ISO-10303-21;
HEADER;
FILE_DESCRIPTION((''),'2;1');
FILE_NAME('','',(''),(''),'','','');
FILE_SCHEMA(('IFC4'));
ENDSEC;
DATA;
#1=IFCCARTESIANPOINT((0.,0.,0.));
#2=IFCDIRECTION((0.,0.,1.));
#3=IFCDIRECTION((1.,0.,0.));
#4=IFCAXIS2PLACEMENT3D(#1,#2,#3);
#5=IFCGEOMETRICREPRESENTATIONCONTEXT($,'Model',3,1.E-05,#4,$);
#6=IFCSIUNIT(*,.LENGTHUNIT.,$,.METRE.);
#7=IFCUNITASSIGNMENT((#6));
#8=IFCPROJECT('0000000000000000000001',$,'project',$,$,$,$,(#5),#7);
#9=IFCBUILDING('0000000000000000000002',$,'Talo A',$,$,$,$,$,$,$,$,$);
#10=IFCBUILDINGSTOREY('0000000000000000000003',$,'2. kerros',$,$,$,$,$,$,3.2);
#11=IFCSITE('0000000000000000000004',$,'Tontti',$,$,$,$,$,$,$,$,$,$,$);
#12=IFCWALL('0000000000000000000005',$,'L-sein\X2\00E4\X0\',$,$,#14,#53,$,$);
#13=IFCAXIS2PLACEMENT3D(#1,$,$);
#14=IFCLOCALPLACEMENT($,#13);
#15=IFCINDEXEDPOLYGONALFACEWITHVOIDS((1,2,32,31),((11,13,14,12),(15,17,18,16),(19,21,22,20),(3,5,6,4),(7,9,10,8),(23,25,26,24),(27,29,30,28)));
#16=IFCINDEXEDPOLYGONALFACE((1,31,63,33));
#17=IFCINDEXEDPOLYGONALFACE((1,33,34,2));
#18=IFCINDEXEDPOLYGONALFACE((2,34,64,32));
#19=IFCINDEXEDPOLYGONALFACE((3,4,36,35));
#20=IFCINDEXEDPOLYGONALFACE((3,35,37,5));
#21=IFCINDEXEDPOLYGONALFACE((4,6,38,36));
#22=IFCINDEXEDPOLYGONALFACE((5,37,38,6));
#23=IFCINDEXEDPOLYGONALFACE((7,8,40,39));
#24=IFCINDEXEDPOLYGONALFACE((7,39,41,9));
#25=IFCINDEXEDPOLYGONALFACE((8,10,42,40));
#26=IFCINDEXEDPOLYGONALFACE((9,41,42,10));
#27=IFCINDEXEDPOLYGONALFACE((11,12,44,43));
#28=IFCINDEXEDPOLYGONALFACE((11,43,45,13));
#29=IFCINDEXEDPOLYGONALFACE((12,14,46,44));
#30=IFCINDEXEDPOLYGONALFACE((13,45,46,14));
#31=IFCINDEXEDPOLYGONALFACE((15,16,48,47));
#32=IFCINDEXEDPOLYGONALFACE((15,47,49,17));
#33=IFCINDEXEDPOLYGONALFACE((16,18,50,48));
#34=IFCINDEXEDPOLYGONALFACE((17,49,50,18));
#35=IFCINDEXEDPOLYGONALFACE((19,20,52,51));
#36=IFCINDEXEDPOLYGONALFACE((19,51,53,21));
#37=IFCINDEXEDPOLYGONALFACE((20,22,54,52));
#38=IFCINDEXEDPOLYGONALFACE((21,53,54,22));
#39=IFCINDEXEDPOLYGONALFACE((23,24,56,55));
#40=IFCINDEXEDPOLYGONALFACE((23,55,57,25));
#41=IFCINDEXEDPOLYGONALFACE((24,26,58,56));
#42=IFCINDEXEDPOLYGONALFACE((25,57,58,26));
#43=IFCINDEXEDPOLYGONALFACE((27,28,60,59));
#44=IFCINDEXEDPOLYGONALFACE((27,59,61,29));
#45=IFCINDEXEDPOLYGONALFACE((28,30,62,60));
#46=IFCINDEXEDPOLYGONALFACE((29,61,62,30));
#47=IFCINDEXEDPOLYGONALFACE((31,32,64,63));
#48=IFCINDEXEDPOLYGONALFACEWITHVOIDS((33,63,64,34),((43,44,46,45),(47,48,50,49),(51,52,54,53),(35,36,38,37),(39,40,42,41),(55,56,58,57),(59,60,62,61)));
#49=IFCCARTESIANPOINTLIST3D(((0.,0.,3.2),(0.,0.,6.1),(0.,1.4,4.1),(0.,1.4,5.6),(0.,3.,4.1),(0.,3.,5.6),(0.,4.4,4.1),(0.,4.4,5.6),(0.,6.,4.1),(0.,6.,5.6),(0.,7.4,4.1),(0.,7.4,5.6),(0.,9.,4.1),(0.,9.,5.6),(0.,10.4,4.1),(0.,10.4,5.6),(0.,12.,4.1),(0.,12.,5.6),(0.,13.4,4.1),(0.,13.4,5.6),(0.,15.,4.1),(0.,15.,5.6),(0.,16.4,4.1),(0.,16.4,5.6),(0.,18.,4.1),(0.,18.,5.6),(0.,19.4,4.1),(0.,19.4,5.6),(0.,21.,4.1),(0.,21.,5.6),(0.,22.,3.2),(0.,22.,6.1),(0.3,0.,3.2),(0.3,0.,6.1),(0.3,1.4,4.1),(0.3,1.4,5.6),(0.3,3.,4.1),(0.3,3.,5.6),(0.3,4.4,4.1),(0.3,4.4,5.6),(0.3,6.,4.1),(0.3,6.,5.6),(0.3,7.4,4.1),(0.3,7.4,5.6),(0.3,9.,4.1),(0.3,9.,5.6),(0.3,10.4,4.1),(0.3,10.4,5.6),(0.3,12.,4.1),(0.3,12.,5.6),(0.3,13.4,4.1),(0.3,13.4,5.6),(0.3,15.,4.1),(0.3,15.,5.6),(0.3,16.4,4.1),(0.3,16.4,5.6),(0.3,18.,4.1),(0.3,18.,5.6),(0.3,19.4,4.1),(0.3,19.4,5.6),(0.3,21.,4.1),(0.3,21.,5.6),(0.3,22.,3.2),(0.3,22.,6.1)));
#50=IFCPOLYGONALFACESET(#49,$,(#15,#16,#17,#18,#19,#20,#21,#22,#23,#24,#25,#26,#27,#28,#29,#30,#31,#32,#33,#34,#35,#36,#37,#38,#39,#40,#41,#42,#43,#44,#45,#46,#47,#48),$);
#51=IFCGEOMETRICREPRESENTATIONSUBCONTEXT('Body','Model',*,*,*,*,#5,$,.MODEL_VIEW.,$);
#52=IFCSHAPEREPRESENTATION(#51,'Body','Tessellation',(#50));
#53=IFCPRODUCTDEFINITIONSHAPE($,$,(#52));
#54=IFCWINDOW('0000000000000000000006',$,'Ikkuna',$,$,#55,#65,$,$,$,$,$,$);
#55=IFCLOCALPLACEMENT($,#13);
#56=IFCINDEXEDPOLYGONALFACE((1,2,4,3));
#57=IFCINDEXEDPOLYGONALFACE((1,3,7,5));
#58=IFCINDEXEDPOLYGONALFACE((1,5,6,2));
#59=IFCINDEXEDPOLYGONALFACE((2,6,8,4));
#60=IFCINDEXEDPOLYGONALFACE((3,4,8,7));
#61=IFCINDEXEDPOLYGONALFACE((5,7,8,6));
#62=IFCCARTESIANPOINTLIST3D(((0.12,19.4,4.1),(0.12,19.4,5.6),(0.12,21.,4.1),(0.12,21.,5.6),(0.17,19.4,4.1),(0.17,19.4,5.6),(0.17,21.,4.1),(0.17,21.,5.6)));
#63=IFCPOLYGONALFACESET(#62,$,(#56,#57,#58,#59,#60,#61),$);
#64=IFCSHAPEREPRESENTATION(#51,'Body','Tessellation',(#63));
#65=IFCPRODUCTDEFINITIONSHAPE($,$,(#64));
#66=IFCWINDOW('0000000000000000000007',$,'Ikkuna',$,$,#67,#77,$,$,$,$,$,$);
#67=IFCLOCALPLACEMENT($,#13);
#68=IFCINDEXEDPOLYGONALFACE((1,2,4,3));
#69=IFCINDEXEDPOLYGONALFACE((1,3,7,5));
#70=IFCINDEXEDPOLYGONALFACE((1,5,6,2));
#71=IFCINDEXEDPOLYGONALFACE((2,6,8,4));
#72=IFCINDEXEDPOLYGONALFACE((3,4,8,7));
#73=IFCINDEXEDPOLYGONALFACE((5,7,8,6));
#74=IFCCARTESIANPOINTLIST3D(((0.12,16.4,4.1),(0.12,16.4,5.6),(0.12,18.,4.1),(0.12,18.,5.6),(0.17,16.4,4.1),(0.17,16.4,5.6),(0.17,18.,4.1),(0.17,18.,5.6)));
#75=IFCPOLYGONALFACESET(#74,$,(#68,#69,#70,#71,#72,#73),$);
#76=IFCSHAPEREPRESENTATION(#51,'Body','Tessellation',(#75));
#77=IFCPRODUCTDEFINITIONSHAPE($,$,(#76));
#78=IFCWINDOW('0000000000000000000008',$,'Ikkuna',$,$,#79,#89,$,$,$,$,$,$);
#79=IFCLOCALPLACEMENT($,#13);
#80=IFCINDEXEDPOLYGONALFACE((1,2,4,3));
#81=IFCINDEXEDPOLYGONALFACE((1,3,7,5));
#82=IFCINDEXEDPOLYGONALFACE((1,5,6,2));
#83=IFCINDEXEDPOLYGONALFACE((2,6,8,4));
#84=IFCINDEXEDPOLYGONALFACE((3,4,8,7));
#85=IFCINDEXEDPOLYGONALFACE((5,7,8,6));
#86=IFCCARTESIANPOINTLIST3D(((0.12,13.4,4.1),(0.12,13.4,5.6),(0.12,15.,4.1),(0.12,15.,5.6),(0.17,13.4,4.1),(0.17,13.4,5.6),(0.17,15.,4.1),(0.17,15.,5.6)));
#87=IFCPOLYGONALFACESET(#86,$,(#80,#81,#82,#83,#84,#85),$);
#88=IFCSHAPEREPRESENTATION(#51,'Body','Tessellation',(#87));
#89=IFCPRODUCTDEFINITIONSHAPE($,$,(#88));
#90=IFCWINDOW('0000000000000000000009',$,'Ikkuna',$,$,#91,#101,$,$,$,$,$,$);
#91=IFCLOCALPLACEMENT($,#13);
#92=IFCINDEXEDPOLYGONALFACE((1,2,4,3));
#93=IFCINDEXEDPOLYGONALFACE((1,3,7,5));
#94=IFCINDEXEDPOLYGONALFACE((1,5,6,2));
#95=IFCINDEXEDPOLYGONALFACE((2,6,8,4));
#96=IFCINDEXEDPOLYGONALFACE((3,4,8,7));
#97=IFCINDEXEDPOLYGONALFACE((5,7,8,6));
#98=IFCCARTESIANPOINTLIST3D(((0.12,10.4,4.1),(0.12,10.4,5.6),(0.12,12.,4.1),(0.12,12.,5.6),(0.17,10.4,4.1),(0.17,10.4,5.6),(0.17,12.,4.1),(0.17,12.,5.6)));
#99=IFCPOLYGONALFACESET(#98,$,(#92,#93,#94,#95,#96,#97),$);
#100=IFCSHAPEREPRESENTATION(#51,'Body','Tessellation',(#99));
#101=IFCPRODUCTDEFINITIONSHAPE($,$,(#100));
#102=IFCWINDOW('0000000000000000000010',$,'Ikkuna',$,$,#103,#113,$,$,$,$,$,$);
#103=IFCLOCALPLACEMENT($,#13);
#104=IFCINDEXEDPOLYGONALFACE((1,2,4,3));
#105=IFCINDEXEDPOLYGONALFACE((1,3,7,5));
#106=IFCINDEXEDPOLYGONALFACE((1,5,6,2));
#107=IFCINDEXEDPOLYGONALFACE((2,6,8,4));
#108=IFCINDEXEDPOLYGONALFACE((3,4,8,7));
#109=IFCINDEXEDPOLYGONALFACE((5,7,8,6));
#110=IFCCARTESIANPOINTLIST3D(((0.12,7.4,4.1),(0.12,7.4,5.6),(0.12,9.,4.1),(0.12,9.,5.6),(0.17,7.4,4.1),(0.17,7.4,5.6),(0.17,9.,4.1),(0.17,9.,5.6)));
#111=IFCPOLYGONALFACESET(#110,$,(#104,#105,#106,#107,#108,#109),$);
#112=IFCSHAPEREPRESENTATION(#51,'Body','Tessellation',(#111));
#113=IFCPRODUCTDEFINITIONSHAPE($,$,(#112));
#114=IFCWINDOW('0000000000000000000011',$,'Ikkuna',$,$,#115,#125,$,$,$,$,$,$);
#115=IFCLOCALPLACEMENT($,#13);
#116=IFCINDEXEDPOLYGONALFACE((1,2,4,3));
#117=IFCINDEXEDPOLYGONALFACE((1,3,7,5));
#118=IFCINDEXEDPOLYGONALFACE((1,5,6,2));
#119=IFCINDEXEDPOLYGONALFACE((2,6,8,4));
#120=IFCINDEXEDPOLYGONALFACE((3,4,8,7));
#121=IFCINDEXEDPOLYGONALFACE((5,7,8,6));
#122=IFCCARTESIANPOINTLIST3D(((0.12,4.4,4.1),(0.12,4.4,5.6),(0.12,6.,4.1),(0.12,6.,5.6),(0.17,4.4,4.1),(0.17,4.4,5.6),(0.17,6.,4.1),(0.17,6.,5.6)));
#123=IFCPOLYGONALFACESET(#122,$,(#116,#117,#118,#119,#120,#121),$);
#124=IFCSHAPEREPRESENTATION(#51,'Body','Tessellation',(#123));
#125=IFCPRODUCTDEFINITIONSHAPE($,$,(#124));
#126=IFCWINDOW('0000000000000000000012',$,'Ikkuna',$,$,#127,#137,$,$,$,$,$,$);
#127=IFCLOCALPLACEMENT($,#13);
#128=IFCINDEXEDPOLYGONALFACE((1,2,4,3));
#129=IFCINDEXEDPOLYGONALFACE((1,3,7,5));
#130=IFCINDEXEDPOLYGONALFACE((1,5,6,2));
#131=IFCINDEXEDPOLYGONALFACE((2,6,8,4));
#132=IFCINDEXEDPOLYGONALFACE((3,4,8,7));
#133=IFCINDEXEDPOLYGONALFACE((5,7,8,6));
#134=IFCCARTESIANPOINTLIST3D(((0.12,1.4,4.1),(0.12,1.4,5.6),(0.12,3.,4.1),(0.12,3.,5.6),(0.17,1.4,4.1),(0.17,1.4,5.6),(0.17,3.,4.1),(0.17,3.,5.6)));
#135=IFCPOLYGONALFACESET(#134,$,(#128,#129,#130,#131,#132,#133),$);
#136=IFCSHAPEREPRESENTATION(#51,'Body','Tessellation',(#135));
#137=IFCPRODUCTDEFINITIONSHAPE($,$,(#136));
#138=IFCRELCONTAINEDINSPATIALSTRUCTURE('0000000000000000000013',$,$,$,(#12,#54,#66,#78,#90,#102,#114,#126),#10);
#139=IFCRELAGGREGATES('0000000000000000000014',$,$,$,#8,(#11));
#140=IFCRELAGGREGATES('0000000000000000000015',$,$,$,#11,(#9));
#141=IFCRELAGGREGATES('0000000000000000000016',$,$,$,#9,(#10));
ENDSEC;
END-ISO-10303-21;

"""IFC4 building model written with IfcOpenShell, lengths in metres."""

from ifc_helpers import new_model, si_unit, frame, origin_with_axes, place, context, subcontext, project, spatial, indexed_curve, outline, extrude, element, save


model = new_model("IFC4")

# Units and contexts
model_context = context("Model", 3, precision=1e-05, world=origin_with_axes())
body_context = subcontext(model_context, "Body", "Model", "MODEL_VIEW")
ifc_project = project(units=[si_unit("LENGTHUNIT", "METRE")], contexts=[model_context])

# Site, building, storey
site = spatial("IfcSite", under=ifc_project, Name="Tontti")
building = spatial("IfcBuilding", under=site, Name="Talo A")
storey = spatial("IfcBuildingStorey", under=building, Name="2. kerros", Elevation=3.2)

# Wall, openings
wall_1_placement = place(None, frame((0.0, 22.0, 3.2), z_axis=(0.0, 0.0, 1.0), x_axis=(0.0, -1.0, 0.0)))
wall_1 = element("IfcWall", 1, at=wall_1_placement, inside=storey, Name="L-seinä", context=body_context, shape_type="SweptSolid", body=[
    extrude(outline(indexed_curve([(0.0, 0.0), (0.0, 0.3), (22.0, 0.3), (22.0, 0.0), (0.0, 0.0)], self_intersect=False)), origin_with_axes(), (0.0, 0.0, 1.0), 2.9),
])
opening_1_placement = place(wall_1_placement, frame((1.0, -0.1, 0.9), z_axis=(0.0, 0.0, 1.0), x_axis=(1.0, 0.0, 0.0)))
element("IfcOpeningElement", 2, at=opening_1_placement, cuts=wall_1, context=body_context, shape_type="SweptSolid", body=[
    extrude(outline(indexed_curve([(0.0, 0.0), (0.0, 0.5), (1.6, 0.5), (1.6, 0.0), (0.0, 0.0)], self_intersect=False)), origin_with_axes(), (0.0, 0.0, 1.0), 1.5),
])
opening_2_placement = place(wall_1_placement, frame((4.0, -0.1, 0.9), z_axis=(0.0, 0.0, 1.0), x_axis=(1.0, 0.0, 0.0)))
element("IfcOpeningElement", 3, at=opening_2_placement, cuts=wall_1, context=body_context, shape_type="SweptSolid", body=[
    extrude(outline(indexed_curve([(0.0, 0.0), (0.0, 0.5), (1.6, 0.5), (1.6, 0.0), (0.0, 0.0)], self_intersect=False)), origin_with_axes(), (0.0, 0.0, 1.0), 1.5),
])
opening_3_placement = place(wall_1_placement, frame((7.0, -0.1, 0.9), z_axis=(0.0, 0.0, 1.0), x_axis=(1.0, 0.0, 0.0)))
element("IfcOpeningElement", 4, at=opening_3_placement, cuts=wall_1, context=body_context, shape_type="SweptSolid", body=[
    extrude(outline(indexed_curve([(0.0, 0.0), (0.0, 0.5), (1.6, 0.5), (1.6, 0.0), (0.0, 0.0)], self_intersect=False)), origin_with_axes(), (0.0, 0.0, 1.0), 1.5),
])
opening_4_placement = place(wall_1_placement, frame((10.0, -0.1, 0.9), z_axis=(0.0, 0.0, 1.0), x_axis=(1.0, 0.0, 0.0)))
element("IfcOpeningElement", 5, at=opening_4_placement, cuts=wall_1, context=body_context, shape_type="SweptSolid", body=[
    extrude(outline(indexed_curve([(0.0, 0.0), (0.0, 0.5), (1.6, 0.5), (1.6, 0.0), (0.0, 0.0)], self_intersect=False)), origin_with_axes(), (0.0, 0.0, 1.0), 1.5),
])
opening_5_placement = place(wall_1_placement, frame((13.0, -0.1, 0.9), z_axis=(0.0, 0.0, 1.0), x_axis=(1.0, 0.0, 0.0)))
element("IfcOpeningElement", 6, at=opening_5_placement, cuts=wall_1, context=body_context, shape_type="SweptSolid", body=[
    extrude(outline(indexed_curve([(0.0, 0.0), (0.0, 0.5), (1.6, 0.5), (1.6, 0.0), (0.0, 0.0)], self_intersect=False)), origin_with_axes(), (0.0, 0.0, 1.0), 1.5),
])
opening_6_placement = place(wall_1_placement, frame((16.0, -0.1, 0.9), z_axis=(0.0, 0.0, 1.0), x_axis=(1.0, 0.0, 0.0)))
element("IfcOpeningElement", 7, at=opening_6_placement, cuts=wall_1, context=body_context, shape_type="SweptSolid", body=[
    extrude(outline(indexed_curve([(0.0, 0.0), (0.0, 0.5), (1.6, 0.5), (1.6, 0.0), (0.0, 0.0)], self_intersect=False)), origin_with_axes(), (0.0, 0.0, 1.0), 1.5),
])
opening_7_placement = place(wall_1_placement, frame((19.0, -0.1, 0.9), z_axis=(0.0, 0.0, 1.0), x_axis=(1.0, 0.0, 0.0)))
element("IfcOpeningElement", 8, at=opening_7_placement, cuts=wall_1, context=body_context, shape_type="SweptSolid", body=[
    extrude(outline(indexed_curve([(0.0, 0.0), (0.0, 0.5), (1.6, 0.5), (1.6, 0.0), (0.0, 0.0)], self_intersect=False)), origin_with_axes(), (0.0, 0.0, 1.0), 1.5),
])

# Windows
for number, where, z_axis, x_axis, name in (
    (9, (0.12, 21.0, 4.1), (0.0, 0.0, 1.0), (0.0, -1.0, 0.0), "Ikkuna"),
    (10, (0.12, 18.0, 4.1), (0.0, 0.0, 1.0), (0.0, -1.0, 0.0), "Ikkuna"),
    (11, (0.12, 15.0, 4.1), (0.0, 0.0, 1.0), (0.0, -1.0, 0.0), "Ikkuna"),
    (12, (0.12, 12.0, 4.1), (0.0, 0.0, 1.0), (0.0, -1.0, 0.0), "Ikkuna"),
    (13, (0.12, 9.0, 4.1), (0.0, 0.0, 1.0), (0.0, -1.0, 0.0), "Ikkuna"),
    (14, (0.12, 6.0, 4.1), (0.0, 0.0, 1.0), (0.0, -1.0, 0.0), "Ikkuna"),
    (15, (0.12, 3.0, 4.1), (0.0, 0.0, 1.0), (0.0, -1.0, 0.0), "Ikkuna"),
):
    element("IfcWindow", number, at=place(None, frame(where, z_axis=z_axis, x_axis=x_axis)), inside=storey, Name=name, context=body_context, shape_type="SweptSolid", body=[
        extrude(outline(indexed_curve([(0.0, 0.0), (0.0, 0.05), (1.6, 0.05), (1.6, 0.0), (0.0, 0.0)], self_intersect=False)), origin_with_axes(), (0.0, 0.0, 1.0), 1.5),
    ])

save(model, "model.ifc")
